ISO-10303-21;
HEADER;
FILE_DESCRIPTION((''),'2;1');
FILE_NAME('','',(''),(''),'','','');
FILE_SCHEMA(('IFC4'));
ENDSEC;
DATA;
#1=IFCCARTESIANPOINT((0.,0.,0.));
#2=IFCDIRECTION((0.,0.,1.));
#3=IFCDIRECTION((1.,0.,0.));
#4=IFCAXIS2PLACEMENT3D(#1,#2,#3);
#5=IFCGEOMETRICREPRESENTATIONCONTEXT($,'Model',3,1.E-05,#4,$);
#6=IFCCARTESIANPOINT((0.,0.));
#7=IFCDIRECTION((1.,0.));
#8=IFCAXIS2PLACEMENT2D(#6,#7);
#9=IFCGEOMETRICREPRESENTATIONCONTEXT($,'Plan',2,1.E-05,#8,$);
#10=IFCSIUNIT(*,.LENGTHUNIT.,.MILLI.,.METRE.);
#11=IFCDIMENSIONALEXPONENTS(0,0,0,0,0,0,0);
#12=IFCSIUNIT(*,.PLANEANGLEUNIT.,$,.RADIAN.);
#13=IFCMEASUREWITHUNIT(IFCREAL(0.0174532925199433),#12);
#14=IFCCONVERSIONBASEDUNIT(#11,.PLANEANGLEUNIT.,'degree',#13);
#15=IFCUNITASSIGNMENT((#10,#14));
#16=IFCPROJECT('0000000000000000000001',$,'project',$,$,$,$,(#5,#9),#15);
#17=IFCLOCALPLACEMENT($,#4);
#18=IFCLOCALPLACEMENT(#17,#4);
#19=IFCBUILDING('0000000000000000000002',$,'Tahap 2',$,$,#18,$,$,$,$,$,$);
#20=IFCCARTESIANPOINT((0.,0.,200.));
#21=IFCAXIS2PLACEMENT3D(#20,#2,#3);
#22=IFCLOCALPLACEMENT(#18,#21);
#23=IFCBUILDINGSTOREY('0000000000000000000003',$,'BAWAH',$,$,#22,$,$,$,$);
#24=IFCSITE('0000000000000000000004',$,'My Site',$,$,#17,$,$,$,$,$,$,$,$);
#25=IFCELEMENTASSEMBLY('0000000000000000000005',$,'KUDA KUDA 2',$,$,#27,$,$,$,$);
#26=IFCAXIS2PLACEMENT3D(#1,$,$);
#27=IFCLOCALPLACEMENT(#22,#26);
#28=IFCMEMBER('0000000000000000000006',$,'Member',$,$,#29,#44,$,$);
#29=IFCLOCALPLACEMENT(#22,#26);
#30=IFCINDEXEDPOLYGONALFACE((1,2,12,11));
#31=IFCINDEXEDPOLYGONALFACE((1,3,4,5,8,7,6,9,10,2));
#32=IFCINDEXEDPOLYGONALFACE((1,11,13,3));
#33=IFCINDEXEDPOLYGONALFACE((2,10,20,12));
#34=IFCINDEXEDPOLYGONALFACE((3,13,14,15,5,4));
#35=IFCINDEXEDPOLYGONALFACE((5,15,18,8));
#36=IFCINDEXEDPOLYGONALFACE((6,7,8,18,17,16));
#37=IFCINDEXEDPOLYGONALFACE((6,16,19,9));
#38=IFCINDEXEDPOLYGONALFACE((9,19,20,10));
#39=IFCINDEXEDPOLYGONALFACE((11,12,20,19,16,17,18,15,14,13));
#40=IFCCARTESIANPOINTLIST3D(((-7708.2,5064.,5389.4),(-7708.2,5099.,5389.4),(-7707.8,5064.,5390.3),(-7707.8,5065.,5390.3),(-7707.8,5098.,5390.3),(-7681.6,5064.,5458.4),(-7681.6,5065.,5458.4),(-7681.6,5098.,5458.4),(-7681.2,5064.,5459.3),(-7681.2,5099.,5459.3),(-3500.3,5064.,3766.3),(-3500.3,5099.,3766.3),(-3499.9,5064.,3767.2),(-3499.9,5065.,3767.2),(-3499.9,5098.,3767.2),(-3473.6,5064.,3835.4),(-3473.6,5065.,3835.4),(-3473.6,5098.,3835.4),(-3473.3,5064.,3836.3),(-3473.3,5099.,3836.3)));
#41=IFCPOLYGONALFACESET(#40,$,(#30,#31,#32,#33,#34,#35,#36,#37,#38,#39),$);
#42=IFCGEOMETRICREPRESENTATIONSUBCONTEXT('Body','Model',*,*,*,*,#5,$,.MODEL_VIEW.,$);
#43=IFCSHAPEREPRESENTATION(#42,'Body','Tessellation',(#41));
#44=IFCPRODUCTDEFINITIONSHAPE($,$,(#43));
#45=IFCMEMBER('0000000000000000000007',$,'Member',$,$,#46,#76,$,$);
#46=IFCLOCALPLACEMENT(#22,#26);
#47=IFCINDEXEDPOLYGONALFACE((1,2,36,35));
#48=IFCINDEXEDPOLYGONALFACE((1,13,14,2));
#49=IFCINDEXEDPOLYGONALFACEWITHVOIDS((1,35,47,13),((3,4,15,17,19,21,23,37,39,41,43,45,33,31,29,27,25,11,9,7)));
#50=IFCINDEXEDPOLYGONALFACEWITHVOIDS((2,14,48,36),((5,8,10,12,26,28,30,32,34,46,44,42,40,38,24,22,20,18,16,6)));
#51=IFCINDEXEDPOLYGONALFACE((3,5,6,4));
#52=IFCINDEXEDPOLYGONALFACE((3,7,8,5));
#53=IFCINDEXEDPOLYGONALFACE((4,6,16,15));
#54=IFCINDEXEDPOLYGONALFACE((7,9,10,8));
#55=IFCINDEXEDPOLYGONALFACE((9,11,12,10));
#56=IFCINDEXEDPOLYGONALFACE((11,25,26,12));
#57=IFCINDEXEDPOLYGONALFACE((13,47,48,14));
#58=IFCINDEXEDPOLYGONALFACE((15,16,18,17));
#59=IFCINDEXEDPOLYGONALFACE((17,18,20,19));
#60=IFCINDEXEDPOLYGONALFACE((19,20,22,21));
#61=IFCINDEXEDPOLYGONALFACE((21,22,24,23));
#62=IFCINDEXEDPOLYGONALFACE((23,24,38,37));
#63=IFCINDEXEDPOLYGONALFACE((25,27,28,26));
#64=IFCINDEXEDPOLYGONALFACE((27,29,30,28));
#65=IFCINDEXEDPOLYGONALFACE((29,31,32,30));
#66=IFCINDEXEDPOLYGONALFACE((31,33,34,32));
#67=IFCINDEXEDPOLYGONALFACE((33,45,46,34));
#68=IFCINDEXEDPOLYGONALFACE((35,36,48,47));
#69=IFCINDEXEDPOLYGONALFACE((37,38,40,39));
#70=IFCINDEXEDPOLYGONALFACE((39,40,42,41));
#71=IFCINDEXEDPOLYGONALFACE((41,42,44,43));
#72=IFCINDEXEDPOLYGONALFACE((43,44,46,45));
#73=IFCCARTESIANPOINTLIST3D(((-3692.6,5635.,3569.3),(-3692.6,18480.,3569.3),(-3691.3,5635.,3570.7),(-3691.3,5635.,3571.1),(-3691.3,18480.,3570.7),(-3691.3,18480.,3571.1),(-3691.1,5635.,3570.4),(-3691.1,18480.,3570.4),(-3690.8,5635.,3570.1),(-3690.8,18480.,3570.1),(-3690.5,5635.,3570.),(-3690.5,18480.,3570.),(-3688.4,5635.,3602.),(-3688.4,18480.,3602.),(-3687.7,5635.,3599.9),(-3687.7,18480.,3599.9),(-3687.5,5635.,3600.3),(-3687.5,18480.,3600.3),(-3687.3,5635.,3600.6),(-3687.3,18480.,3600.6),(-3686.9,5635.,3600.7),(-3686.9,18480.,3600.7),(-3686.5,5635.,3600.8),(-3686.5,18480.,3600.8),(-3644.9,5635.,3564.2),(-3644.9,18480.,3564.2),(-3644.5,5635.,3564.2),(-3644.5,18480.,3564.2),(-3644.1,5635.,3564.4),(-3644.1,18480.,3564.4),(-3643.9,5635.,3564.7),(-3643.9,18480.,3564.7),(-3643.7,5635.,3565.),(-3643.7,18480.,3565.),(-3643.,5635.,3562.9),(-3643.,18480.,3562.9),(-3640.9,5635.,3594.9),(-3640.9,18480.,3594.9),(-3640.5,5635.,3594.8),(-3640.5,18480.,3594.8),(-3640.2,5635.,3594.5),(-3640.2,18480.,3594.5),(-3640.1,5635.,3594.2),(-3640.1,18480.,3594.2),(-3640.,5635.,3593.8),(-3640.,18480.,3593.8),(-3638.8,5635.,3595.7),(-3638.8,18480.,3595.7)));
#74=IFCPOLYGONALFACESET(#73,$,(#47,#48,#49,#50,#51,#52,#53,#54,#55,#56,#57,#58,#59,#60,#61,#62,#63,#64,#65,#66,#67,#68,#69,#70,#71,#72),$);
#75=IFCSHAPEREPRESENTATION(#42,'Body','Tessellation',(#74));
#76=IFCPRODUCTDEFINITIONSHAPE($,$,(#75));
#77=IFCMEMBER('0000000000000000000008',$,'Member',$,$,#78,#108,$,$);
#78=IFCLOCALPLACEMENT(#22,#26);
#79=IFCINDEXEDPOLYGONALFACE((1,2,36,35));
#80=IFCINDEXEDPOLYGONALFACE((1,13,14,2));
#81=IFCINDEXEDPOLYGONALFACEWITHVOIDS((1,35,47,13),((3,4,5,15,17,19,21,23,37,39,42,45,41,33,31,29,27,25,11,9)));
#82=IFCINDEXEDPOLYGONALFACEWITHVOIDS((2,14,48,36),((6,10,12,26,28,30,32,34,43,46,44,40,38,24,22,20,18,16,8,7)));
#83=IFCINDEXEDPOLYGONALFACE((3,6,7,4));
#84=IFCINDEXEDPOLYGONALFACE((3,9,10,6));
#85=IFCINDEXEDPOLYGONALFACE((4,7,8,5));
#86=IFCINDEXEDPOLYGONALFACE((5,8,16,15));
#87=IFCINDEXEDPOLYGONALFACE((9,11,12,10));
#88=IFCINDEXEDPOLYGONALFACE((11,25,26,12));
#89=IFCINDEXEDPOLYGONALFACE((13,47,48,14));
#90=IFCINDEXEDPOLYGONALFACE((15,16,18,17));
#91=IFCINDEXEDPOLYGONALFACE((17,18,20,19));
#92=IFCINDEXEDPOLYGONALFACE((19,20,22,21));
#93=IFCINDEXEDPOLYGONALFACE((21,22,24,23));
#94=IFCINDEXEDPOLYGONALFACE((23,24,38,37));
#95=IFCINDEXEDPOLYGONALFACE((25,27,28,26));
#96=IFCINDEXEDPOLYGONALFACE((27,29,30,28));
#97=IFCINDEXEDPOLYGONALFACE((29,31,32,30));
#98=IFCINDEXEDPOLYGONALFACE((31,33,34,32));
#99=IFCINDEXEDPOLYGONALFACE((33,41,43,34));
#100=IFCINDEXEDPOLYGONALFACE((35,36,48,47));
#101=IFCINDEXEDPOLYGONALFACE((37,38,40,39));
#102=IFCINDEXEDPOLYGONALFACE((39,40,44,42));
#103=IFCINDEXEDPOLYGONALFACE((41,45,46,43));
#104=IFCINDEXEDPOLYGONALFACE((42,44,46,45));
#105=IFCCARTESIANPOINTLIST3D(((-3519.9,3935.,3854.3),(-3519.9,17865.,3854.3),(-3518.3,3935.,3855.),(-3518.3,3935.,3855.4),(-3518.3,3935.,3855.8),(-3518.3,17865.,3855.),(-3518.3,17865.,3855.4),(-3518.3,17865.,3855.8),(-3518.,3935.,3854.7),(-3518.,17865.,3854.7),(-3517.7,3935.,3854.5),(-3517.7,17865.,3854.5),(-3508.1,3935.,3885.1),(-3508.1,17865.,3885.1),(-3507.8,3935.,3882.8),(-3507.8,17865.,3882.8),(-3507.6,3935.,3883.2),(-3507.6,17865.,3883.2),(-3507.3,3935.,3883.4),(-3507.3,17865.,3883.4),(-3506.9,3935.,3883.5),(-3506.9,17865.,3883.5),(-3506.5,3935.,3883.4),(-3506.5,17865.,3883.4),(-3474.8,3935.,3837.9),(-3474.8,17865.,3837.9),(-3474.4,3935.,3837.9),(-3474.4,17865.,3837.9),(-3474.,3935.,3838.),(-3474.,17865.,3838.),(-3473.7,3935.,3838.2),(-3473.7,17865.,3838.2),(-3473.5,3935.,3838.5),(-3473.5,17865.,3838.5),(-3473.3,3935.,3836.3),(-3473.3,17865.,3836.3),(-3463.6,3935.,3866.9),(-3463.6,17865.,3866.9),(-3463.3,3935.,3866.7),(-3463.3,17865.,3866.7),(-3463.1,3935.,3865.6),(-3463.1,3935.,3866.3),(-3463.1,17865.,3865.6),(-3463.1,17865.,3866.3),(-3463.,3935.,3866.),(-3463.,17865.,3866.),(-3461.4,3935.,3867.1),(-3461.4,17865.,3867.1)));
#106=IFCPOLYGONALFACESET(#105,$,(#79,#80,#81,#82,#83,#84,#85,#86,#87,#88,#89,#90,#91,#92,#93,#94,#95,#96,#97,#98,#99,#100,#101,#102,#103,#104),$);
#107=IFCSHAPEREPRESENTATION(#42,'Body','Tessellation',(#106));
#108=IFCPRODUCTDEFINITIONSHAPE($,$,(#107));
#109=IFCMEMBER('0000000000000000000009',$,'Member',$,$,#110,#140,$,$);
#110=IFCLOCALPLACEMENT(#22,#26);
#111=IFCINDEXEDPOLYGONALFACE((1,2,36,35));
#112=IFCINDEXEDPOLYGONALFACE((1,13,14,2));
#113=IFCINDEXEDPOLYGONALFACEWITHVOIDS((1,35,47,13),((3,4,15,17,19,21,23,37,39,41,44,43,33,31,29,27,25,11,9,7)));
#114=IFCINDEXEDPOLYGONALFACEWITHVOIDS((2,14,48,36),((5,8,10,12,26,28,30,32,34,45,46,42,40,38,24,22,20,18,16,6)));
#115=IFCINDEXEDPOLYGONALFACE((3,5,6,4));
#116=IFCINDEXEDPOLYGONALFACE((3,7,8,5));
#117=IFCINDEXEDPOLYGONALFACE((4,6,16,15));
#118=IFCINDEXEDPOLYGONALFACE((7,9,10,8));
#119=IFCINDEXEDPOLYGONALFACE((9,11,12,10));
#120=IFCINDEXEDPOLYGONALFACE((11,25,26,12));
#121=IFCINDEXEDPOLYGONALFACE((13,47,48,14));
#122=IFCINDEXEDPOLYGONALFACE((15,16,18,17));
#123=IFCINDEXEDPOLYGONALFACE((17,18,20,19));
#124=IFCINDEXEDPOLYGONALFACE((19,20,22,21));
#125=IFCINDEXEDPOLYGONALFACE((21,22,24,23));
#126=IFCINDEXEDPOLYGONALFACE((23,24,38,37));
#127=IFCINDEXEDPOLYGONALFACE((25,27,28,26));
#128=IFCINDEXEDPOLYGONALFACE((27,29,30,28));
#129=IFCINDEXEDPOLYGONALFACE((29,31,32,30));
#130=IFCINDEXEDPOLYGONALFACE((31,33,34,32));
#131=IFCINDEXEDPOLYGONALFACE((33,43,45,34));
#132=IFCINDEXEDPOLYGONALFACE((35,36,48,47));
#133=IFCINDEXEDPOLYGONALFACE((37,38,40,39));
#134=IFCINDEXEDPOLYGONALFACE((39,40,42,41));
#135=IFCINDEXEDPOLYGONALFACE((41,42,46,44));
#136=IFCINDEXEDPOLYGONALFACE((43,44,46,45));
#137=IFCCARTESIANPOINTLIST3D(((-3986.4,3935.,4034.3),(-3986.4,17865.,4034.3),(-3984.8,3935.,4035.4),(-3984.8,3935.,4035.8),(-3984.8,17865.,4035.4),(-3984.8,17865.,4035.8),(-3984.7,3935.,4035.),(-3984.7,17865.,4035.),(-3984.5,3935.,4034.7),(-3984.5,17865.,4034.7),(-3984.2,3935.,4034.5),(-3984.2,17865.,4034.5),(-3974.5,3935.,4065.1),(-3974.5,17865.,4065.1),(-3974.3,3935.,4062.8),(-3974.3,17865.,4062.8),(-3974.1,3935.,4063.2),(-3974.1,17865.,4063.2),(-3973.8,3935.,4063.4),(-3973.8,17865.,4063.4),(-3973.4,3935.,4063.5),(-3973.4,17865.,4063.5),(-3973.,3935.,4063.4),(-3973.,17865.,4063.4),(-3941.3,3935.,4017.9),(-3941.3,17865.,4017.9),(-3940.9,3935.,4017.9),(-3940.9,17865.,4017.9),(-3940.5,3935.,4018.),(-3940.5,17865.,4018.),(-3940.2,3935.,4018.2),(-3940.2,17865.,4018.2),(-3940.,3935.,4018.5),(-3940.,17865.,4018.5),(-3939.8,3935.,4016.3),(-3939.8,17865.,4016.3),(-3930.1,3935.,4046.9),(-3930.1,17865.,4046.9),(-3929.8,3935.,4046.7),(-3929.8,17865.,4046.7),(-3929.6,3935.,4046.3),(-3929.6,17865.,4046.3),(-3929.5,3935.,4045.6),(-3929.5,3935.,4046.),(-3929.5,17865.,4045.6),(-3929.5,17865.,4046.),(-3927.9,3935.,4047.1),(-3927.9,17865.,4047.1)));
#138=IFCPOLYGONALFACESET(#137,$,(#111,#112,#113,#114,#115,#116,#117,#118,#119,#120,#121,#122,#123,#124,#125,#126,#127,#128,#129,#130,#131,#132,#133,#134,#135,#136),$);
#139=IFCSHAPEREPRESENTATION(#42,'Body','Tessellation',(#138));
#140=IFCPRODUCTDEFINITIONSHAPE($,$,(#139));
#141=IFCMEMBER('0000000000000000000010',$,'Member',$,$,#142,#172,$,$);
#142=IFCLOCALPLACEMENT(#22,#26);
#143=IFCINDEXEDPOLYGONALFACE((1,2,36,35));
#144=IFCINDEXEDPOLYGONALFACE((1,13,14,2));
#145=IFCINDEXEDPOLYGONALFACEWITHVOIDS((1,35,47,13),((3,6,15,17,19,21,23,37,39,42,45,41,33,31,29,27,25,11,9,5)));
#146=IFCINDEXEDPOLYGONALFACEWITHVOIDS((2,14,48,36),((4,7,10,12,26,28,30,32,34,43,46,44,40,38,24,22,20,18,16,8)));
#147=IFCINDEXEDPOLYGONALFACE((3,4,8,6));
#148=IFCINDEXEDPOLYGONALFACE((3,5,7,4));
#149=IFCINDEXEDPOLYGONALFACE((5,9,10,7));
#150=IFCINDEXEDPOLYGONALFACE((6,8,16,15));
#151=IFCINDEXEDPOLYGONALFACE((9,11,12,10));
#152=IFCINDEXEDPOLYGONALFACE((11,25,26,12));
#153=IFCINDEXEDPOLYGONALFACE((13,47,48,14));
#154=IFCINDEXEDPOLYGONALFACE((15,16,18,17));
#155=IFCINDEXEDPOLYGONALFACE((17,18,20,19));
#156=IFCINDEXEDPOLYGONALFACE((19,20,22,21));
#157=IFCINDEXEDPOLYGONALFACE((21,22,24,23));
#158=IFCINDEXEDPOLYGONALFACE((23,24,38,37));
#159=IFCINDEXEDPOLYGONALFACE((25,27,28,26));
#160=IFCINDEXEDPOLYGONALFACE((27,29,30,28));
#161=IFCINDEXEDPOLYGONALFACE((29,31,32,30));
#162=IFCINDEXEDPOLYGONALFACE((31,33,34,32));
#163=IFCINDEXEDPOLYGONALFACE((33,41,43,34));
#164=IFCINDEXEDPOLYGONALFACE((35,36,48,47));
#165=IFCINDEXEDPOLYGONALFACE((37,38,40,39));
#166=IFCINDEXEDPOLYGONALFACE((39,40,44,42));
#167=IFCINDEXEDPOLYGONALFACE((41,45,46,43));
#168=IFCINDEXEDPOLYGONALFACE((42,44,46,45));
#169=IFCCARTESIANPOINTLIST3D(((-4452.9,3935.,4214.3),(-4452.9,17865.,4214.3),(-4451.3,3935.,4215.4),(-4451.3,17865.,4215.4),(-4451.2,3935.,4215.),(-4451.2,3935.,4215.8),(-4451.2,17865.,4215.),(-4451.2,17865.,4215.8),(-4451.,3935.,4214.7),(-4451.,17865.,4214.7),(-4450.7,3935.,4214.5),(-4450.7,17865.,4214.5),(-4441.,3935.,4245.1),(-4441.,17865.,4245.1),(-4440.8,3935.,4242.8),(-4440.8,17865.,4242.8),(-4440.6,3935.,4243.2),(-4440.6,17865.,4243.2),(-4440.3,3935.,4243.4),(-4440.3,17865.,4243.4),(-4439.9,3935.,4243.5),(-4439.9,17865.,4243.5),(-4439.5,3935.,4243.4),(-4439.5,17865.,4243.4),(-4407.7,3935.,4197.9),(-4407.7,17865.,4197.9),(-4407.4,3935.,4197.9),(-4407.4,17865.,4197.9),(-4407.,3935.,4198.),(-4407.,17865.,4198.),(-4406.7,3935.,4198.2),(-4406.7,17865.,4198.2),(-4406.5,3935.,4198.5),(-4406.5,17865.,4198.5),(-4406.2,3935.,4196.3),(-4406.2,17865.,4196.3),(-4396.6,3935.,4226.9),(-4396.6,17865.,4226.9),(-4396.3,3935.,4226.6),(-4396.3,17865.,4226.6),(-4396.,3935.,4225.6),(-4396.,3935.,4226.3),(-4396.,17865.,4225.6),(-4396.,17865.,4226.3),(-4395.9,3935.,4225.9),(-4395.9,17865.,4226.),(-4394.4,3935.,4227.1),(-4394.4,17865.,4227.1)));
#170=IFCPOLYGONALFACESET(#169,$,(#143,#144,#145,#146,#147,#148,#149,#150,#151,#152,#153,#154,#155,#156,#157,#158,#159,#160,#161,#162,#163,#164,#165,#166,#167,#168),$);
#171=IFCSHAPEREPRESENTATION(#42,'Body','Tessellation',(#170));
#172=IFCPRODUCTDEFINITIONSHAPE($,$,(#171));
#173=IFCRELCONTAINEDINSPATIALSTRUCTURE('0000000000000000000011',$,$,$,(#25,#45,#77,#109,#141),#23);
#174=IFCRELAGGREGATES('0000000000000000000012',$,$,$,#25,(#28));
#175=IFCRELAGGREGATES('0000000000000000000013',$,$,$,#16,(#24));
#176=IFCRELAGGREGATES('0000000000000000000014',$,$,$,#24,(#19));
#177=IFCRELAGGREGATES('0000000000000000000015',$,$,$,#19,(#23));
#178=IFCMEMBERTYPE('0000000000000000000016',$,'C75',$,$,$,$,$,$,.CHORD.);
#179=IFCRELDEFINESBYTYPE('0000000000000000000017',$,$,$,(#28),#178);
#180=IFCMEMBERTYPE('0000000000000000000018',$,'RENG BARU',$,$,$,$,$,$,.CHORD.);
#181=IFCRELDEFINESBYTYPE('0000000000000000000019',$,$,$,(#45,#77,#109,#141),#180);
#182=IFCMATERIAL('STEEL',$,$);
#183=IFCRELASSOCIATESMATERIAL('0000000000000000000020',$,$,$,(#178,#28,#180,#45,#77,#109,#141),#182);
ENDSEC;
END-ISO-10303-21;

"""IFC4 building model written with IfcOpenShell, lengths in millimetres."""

from ifc_helpers import new_model, entity, si_unit, converted_unit, frame, origin_with_axes, origin_2d_with_axis, place, context, subcontext, project, spatial, hollow_rectangle, c_section, extrude, material, material_profile, profile_set, profile_usage, type_object, element, aggregate, save


model = new_model("IFC4")

# Units and contexts
model_context = context("Model", 3, precision=1e-05, world=origin_with_axes())
plan_context = context("Plan", 2, precision=1e-05, world=origin_2d_with_axis())
body_context = subcontext(model_context, "Body", "Model", "MODEL_VIEW")
ifc_project = project(units=[si_unit("LENGTHUNIT", "METRE", prefix="MILLI"), converted_unit("PLANEANGLEUNIT", "degree", entity("IfcReal", 0.0174532925199433), si_unit("PLANEANGLEUNIT", "RADIAN"), dimensions=[0, 0, 0, 0, 0, 0, 0])], contexts=[model_context, plan_context])

# Site, building, storey
site_placement = place(None, origin_with_axes())
site = spatial("IfcSite", under=ifc_project, at=site_placement, Name="My Site")
building_placement = place(site_placement, origin_with_axes())
building = spatial("IfcBuilding", under=site, at=building_placement, Name="Tahap 2")
storey_placement = place(building_placement, frame((0.0, 0.0, 200.0), z_axis=(0.0, 0.0, 1.0), x_axis=(1.0, 0.0, 0.0)))
storey = spatial("IfcBuildingStorey", under=building, at=storey_placement, Name="BAWAH")

# Element assembly, member
assembly_placement = place(storey_placement, frame((-3938.5, 5099.0, 3935.3), z_axis=(0.0, 0.0, 1.0), x_axis=(1.0, 0.0, 0.0)))
assembly = element("IfcElementAssembly", 1, at=assembly_placement, inside=storey, Name="KUDA KUDA 2")
ifc_material_1 = material(Name="STEEL")
ifc_material_profile_1 = material_profile(ifc_material_1, c_section(Depth=75.0, Width=35.0, WallThickness=1.0, Girth=1.0, kind="CURVE"))
ifc_profile_set_1 = profile_set([ifc_material_profile_1])
ifc_profile_usage_1 = profile_usage(ifc_profile_set_1, cardinal=1)
member_type_1 = type_object("IfcMemberType", Name="C75", PredefinedType="CHORD", material=ifc_profile_set_1)
member_1_placement = place(assembly_placement, frame((438.2, -35.0, -169.0), z_axis=(-0.933001, -0.000001, 0.359873), x_axis=(0.000001, -1.0, 0.0)))
member_1 = element("IfcMember", 2, at=member_1_placement, type_object=member_type_1, material=ifc_profile_usage_1, Name="Member", context=body_context, shape_type="SweptSolid", body=[
    extrude(c_section(Depth=75.0, Width=35.0, WallThickness=1.0, Girth=1.0, kind="CURVE"), frame((-17.5, 37.5, 0.0), z_axis=(0.0, 0.0, 1.0), x_axis=(1.0, 0.0, 0.0)), (0.0, 0.0, 1.0), 4510.1),
])
aggregate(assembly, [member_1])

# Members
ifc_material_profile_2 = material_profile(ifc_material_1, hollow_rectangle(XDim=50.0, YDim=33.0, WallThickness=1.0, InnerFilletRadius=1.0, OuterFilletRadius=0.0, kind="CURVE"))
ifc_profile_set_2 = profile_set([ifc_material_profile_2])
ifc_profile_usage_2 = profile_usage(ifc_profile_set_2, cardinal=3)
member_type_2 = type_object("IfcMemberType", Name="RENG BARU", PredefinedType="CHORD", material=ifc_profile_set_2)
member_2_placement = place(storey_placement, frame((-3643.0, 5635.0, 3562.9), z_axis=(0.0, 1.0, 0.0), x_axis=(-0.991894, 0.0, 0.127065)))
element("IfcMember", 3, at=member_2_placement, inside=storey, type_object=member_type_2, material=ifc_profile_usage_2, Name="Member", context=body_context, shape_type="SweptSolid", body=[
    extrude(hollow_rectangle(XDim=50.0, YDim=33.0, WallThickness=1.0, InnerFilletRadius=1.0, OuterFilletRadius=0.0, kind="CURVE"), frame((25.0, 16.5, 0.0), z_axis=(0.0, 0.0, 1.0), x_axis=(1.0, 0.0, 0.0)), (0.0, 0.0, 1.0), 12845.0),
])
ifc_profile_usage_3 = profile_usage(ifc_profile_set_2, cardinal=3)
member_3_placement = place(storey_placement, frame((-3473.3, 3935.0, 3836.3), z_axis=(0.0, 1.0, 0.0), x_axis=(-0.932954, 0.0, 0.359997)))
element("IfcMember", 4, at=member_3_placement, inside=storey, type_object=member_type_2, material=ifc_profile_usage_3, Name="Member", context=body_context, shape_type="SweptSolid", body=[
    extrude(hollow_rectangle(XDim=50.0, YDim=33.0, WallThickness=1.0, InnerFilletRadius=1.0, OuterFilletRadius=0.0, kind="CURVE"), frame((25.0, 16.5, 0.0), z_axis=(0.0, 0.0, 1.0), x_axis=(1.0, 0.0, 0.0)), (0.0, 0.0, 1.0), 13930.0),
])
ifc_profile_usage_4 = profile_usage(ifc_profile_set_2, cardinal=3)
member_4_placement = place(storey_placement, frame((-3939.8, 3935.0, 4016.3), z_axis=(0.0, 1.0, 0.0), x_axis=(-0.932954, 0.0, 0.359997)))
element("IfcMember", 5, at=member_4_placement, inside=storey, type_object=member_type_2, material=ifc_profile_usage_4, Name="Member", context=body_context, shape_type="SweptSolid", body=[
    extrude(hollow_rectangle(XDim=50.0, YDim=33.0, WallThickness=1.0, InnerFilletRadius=1.0, OuterFilletRadius=0.0, kind="CURVE"), frame((25.0, 16.5, 0.0), z_axis=(0.0, 0.0, 1.0), x_axis=(1.0, 0.0, 0.0)), (0.0, 0.0, 1.0), 13930.0),
])
ifc_profile_usage_5 = profile_usage(ifc_profile_set_2, cardinal=3)
member_5_placement = place(storey_placement, frame((-4406.2, 3935.0, 4196.3), z_axis=(0.0, 1.0, 0.0), x_axis=(-0.932954, 0.0, 0.359997)))
element("IfcMember", 6, at=member_5_placement, inside=storey, type_object=member_type_2, material=ifc_profile_usage_5, Name="Member", context=body_context, shape_type="SweptSolid", body=[
    extrude(hollow_rectangle(XDim=50.0, YDim=33.0, WallThickness=1.0, InnerFilletRadius=1.0, OuterFilletRadius=0.0, kind="CURVE"), frame((25.0, 16.5, 0.0), z_axis=(0.0, 0.0, 1.0), x_axis=(1.0, 0.0, 0.0)), (0.0, 0.0, 1.0), 13930.0),
])

save(model, "model.ifc")
